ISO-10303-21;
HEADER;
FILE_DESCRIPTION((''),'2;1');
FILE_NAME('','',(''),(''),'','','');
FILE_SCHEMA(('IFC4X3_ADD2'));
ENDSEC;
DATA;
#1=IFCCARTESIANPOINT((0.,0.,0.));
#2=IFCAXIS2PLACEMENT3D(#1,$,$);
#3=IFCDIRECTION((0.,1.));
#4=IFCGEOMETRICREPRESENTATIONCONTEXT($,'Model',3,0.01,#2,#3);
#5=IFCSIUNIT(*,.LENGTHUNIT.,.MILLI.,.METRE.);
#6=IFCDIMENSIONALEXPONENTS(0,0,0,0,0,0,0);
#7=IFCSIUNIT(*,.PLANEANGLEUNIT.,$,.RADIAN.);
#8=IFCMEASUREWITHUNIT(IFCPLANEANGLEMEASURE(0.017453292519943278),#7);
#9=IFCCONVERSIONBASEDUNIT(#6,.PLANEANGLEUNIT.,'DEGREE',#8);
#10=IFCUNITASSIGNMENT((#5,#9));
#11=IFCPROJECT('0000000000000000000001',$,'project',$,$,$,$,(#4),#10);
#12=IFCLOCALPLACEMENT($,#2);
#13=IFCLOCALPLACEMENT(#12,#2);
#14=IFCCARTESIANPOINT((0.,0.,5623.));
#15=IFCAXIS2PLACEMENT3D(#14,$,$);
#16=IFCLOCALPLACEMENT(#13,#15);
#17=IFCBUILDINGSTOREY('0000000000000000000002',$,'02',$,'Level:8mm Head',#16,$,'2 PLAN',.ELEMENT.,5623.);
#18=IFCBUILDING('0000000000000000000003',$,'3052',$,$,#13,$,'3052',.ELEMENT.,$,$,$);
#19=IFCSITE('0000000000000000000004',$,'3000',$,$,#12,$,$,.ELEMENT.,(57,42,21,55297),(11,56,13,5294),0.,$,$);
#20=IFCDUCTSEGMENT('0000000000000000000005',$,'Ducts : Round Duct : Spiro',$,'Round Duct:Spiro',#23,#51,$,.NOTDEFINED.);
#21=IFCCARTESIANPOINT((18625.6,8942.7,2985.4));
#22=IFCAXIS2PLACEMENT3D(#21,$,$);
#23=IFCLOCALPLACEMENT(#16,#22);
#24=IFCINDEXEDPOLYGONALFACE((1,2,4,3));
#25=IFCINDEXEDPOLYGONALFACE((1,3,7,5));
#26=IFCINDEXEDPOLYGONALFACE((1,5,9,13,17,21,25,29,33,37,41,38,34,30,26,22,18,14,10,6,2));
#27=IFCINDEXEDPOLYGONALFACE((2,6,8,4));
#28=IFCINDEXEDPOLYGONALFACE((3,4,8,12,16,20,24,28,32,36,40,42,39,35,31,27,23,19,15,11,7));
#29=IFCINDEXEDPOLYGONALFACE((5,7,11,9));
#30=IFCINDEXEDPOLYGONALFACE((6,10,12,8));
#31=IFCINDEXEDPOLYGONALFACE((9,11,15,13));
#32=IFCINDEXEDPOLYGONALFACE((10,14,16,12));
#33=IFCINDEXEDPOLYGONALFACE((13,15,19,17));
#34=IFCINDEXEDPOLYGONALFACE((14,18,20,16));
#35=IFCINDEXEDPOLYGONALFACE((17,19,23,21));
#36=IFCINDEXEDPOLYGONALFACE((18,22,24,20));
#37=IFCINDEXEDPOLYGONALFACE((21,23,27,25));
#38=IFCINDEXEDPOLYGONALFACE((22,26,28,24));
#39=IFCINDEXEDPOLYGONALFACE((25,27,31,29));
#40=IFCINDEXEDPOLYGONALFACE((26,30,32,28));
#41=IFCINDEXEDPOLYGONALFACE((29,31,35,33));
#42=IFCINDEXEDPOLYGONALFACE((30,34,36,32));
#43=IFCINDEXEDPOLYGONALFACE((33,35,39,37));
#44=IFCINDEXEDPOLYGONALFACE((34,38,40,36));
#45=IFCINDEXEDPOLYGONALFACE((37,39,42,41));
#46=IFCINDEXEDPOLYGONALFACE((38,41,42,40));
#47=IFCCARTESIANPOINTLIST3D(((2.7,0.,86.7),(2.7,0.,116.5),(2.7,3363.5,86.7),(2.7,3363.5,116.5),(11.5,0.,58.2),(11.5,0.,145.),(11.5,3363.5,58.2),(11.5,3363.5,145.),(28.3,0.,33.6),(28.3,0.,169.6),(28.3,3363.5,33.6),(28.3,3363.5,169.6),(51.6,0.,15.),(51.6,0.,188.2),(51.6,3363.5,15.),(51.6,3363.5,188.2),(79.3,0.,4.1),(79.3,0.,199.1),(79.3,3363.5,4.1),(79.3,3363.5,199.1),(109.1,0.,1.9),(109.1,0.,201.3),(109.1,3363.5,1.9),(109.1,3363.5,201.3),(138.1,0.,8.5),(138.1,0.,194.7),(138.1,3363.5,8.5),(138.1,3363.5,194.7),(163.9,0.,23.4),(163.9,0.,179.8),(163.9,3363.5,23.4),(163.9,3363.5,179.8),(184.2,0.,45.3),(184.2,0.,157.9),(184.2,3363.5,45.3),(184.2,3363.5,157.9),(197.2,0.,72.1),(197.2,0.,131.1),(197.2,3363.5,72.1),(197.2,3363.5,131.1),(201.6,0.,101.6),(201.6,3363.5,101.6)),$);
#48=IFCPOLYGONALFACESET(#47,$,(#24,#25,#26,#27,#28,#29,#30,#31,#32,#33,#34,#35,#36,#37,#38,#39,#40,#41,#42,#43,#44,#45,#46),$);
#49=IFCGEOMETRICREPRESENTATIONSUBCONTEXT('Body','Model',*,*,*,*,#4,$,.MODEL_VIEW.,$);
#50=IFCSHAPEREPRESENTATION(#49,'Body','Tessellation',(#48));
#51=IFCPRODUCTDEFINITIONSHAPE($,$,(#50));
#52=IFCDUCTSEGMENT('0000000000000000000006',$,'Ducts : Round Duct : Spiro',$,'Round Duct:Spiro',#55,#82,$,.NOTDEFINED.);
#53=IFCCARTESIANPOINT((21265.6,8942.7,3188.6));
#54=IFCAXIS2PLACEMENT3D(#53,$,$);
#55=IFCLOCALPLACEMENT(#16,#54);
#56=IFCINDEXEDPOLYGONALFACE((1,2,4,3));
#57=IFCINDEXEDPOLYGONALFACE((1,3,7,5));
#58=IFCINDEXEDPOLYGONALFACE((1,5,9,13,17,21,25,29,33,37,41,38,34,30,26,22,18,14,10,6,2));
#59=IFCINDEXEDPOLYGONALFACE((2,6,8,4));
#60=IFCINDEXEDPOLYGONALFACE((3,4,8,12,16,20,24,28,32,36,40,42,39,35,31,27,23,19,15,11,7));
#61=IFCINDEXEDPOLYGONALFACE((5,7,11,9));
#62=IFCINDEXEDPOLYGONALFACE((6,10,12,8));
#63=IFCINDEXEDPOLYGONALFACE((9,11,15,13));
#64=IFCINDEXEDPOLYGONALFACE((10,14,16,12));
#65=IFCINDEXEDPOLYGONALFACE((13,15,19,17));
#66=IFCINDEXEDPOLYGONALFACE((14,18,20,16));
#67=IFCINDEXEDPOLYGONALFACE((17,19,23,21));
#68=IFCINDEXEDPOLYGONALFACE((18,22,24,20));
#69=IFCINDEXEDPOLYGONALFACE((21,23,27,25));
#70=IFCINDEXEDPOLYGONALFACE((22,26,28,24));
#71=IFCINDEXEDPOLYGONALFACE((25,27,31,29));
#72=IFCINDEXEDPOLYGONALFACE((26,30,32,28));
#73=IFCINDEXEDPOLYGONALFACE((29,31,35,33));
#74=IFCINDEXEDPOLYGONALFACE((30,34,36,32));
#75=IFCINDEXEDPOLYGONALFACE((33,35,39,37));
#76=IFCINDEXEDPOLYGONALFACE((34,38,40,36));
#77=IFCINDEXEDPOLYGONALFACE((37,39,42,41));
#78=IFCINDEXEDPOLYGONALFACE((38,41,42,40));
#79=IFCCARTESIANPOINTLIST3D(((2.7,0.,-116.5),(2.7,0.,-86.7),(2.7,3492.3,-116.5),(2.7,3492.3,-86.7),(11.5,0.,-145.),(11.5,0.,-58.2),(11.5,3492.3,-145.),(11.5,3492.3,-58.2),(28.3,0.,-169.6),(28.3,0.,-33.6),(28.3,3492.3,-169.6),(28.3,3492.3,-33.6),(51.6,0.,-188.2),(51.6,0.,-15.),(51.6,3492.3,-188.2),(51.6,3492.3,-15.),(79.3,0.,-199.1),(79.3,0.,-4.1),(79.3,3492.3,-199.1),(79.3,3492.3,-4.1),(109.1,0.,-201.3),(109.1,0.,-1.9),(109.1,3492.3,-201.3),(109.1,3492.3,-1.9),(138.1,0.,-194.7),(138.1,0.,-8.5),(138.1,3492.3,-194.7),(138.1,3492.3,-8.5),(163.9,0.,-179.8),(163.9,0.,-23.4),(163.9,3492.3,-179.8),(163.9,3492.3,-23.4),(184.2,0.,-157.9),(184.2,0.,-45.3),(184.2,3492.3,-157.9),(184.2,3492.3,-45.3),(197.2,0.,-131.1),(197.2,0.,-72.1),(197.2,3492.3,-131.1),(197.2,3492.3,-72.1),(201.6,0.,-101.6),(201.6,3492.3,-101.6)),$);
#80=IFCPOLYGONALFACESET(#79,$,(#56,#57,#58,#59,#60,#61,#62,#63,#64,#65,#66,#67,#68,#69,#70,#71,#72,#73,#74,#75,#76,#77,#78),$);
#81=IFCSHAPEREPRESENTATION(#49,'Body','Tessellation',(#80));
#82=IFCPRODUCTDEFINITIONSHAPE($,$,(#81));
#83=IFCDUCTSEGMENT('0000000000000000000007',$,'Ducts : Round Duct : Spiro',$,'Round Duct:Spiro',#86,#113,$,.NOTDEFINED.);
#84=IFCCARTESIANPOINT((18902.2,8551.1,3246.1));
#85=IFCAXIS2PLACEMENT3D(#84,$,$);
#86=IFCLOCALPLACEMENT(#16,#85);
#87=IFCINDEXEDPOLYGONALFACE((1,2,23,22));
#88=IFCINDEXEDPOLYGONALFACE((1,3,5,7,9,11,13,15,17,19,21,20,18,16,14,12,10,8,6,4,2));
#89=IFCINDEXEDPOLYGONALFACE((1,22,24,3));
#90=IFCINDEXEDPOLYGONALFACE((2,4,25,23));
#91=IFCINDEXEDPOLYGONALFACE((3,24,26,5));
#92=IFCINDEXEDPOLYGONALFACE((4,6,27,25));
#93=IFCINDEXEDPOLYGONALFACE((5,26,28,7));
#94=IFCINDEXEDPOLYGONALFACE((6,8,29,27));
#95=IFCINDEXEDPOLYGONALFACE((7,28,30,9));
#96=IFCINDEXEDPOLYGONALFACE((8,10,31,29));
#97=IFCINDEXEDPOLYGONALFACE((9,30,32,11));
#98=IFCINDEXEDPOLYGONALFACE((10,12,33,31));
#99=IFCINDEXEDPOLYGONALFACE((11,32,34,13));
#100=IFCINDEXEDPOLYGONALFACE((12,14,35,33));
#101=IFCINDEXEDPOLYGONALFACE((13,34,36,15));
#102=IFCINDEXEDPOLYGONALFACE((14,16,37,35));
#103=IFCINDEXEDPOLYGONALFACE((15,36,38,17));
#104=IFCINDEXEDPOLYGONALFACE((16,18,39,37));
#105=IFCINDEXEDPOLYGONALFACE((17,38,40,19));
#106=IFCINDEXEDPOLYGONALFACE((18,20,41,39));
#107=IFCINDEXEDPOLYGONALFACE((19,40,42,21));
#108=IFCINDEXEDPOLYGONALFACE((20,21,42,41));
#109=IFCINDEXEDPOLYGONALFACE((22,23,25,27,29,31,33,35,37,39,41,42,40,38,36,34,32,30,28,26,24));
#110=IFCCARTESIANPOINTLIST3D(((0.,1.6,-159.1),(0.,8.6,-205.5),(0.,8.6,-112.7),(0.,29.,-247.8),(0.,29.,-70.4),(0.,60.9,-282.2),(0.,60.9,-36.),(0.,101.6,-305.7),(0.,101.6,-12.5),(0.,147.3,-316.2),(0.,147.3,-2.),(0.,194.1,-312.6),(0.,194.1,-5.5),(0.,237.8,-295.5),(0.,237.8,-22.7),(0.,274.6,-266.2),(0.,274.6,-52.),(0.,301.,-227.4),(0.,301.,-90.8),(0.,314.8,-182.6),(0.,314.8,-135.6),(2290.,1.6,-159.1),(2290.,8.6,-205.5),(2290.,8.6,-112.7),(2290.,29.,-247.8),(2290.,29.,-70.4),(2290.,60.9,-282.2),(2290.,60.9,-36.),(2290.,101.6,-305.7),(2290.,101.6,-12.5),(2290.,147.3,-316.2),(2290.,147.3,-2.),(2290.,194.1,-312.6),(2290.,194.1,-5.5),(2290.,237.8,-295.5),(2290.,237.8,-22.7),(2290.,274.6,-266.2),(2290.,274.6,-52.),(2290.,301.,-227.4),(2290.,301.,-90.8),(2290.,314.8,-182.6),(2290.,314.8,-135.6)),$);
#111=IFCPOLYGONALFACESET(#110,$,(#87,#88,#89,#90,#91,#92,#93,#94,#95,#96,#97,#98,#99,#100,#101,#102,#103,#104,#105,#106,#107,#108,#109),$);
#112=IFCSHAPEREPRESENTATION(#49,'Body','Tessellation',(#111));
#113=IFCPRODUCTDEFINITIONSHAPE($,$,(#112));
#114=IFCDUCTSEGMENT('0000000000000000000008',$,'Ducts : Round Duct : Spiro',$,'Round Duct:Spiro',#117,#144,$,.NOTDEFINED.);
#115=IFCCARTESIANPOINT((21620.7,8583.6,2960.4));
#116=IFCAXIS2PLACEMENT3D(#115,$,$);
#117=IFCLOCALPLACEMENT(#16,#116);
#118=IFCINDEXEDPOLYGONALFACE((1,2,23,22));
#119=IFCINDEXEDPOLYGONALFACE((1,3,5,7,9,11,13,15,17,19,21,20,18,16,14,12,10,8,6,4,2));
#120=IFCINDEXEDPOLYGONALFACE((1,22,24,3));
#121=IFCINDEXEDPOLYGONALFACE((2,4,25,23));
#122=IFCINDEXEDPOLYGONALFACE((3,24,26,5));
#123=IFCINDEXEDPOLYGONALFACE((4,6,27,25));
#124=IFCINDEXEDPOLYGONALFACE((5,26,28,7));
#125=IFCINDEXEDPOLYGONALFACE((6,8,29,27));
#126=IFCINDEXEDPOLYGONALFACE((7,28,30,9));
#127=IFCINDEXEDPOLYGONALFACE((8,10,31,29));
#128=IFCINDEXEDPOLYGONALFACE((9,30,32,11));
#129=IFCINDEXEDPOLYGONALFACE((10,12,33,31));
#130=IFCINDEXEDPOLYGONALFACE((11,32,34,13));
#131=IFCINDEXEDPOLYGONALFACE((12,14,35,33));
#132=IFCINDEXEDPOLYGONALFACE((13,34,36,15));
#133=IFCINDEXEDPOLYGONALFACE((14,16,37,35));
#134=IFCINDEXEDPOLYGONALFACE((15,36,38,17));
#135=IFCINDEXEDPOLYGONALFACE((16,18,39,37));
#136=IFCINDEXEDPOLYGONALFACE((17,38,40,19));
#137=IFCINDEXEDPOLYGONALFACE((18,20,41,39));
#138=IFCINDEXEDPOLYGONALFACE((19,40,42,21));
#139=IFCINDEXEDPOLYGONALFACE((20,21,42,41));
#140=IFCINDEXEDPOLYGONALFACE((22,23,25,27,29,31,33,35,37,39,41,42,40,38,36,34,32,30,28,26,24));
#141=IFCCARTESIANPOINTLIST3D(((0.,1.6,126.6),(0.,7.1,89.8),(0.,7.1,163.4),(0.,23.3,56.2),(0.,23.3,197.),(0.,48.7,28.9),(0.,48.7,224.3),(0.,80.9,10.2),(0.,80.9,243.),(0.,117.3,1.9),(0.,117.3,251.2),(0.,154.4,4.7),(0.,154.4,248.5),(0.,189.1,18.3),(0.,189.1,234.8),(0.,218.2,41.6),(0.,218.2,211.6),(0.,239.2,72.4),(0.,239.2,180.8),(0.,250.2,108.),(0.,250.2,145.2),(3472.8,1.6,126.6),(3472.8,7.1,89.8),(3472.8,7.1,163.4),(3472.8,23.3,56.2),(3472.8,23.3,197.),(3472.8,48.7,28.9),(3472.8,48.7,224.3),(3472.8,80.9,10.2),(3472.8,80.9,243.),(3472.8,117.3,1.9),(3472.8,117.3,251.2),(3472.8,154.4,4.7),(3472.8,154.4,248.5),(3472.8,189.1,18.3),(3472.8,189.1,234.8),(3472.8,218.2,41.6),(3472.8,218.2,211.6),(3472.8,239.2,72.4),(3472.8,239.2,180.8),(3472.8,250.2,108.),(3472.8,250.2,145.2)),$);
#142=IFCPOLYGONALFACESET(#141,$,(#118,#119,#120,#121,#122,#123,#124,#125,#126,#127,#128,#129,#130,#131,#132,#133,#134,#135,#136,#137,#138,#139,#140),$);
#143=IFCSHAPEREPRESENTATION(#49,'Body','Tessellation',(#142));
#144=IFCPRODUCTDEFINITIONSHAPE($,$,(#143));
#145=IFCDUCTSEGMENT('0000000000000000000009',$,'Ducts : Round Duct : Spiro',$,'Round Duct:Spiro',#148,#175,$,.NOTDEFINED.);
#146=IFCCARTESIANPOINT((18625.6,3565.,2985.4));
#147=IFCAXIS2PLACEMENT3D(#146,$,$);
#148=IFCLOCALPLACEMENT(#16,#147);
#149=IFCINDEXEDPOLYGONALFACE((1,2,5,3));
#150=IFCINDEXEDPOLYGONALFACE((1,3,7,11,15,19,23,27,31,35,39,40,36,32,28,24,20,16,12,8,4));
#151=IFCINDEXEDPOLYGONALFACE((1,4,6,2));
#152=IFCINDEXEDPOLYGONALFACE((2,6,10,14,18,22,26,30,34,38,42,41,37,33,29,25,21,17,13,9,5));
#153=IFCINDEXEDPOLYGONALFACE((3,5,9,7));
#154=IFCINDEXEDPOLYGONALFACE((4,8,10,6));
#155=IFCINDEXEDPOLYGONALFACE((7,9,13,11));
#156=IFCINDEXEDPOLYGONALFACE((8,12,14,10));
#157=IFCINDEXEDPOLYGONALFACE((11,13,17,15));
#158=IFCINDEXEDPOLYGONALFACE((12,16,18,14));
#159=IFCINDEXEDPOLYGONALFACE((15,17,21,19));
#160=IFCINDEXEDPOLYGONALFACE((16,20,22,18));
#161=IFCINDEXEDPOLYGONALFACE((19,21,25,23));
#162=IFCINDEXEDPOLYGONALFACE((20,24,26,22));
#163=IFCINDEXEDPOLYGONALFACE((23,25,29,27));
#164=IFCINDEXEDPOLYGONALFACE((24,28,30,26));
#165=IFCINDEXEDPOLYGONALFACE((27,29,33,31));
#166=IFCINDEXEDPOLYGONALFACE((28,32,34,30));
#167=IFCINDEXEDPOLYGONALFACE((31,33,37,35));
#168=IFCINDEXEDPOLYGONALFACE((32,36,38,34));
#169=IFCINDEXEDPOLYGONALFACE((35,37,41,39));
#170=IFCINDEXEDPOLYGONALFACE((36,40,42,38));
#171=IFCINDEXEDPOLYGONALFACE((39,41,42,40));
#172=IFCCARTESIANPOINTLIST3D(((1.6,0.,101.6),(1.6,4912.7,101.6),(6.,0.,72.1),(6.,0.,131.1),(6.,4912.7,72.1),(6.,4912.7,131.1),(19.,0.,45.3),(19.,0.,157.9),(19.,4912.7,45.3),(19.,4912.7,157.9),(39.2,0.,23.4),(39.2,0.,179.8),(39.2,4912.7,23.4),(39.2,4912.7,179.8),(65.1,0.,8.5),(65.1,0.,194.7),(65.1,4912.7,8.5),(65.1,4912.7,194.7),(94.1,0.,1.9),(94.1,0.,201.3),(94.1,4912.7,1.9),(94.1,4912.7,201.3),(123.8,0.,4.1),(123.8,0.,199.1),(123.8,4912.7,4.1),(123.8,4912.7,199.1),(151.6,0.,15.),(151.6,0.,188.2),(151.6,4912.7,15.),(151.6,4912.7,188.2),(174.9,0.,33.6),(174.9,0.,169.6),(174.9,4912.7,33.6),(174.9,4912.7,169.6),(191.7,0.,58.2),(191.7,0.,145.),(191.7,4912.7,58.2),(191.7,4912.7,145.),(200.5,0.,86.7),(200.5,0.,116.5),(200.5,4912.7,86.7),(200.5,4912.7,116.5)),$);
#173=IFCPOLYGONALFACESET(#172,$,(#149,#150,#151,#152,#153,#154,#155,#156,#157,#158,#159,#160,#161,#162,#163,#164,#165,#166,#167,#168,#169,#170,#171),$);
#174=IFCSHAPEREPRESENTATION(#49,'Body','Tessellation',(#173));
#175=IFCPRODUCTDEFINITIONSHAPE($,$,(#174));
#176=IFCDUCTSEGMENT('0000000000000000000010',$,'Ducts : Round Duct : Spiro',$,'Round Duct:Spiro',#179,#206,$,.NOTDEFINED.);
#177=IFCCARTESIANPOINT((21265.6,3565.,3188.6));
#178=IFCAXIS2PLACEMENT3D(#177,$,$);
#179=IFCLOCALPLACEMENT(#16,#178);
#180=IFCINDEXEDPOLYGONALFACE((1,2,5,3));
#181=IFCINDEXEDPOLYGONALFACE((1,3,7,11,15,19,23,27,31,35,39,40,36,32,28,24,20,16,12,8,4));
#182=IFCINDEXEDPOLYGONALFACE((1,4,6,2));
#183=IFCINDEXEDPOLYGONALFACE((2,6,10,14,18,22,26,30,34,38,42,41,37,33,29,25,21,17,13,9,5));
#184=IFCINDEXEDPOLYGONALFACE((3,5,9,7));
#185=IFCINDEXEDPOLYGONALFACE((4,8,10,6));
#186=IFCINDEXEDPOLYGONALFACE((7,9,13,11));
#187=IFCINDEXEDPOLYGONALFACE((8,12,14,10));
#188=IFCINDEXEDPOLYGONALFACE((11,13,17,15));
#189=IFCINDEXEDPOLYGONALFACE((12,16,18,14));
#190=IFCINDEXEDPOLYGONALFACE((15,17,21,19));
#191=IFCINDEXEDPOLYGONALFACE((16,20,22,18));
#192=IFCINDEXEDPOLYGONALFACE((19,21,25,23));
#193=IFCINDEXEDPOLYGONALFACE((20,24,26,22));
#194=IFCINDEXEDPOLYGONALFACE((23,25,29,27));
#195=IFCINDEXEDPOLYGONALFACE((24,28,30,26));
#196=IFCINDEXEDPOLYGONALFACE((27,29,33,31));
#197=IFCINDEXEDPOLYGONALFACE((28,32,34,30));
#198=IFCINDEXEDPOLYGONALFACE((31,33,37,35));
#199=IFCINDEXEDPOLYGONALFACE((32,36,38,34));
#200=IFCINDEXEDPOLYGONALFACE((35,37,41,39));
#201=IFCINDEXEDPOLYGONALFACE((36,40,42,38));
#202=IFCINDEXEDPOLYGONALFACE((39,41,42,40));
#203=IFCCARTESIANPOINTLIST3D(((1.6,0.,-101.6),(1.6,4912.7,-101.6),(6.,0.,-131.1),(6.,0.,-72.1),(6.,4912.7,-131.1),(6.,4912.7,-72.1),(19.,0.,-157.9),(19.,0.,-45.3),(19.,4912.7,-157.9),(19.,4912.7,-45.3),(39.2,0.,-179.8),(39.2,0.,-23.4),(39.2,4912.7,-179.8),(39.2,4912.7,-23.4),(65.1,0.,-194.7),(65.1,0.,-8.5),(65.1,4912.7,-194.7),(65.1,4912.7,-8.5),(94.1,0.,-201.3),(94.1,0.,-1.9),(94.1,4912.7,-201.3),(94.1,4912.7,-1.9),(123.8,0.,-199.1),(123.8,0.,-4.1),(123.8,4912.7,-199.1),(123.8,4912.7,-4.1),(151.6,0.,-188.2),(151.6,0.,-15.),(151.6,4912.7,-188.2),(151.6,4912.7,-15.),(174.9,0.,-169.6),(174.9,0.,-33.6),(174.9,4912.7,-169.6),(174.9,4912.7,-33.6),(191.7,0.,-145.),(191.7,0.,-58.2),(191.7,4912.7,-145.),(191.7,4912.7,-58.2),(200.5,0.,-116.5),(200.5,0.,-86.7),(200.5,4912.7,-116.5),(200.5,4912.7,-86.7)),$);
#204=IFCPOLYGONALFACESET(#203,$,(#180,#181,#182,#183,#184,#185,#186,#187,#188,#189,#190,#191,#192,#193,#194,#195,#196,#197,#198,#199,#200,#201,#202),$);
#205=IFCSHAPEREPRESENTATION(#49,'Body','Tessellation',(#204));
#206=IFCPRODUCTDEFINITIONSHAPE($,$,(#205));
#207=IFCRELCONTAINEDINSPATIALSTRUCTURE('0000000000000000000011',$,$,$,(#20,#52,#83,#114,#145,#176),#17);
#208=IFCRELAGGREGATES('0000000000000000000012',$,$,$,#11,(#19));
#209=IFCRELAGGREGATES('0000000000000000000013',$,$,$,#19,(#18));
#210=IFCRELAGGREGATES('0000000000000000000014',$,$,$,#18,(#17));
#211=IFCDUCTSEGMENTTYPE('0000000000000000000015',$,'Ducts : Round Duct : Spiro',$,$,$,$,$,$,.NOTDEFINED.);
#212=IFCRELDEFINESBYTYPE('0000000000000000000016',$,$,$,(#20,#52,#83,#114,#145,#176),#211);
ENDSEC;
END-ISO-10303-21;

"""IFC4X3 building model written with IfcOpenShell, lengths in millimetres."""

from ifc_helpers import new_model, entity, si_unit, converted_unit, direction, frame, frame_2d, origin, origin_2d_with_axis, place, context, subcontext, project, spatial, circle, extrude, type_object, element, save


model = new_model("IFC4X3")

# Units and contexts
model_context = context("Model", 3, precision=0.01, world=origin(), true_north=direction((0.0, 1.0)))
body_context = subcontext(model_context, "Body", "Model", "MODEL_VIEW")
ifc_project = project(units=[si_unit("LENGTHUNIT", "METRE", prefix="MILLI"), converted_unit("PLANEANGLEUNIT", "DEGREE", entity("IfcPlaneAngleMeasure", 0.017453292519943278), si_unit("PLANEANGLEUNIT", "RADIAN"), dimensions=[0, 0, 0, 0, 0, 0, 0])], contexts=[model_context])

# Site, building, storey
site_placement = place(None, origin())
site = spatial("IfcSite", under=ifc_project, at=site_placement, Name="3000", CompositionType="ELEMENT", RefLatitude=(57, 42, 21, 55297), RefLongitude=(11, 56, 13, 5294), RefElevation=0.0)
building_placement = place(site_placement, origin())
building = spatial("IfcBuilding", under=site, at=building_placement, Name="3052", LongName="3052", CompositionType="ELEMENT")
storey_placement = place(building_placement, frame((0.0, 0.0, 5623.0)))
storey = spatial("IfcBuildingStorey", under=building, at=storey_placement, Name="02", ObjectType="Level:8mm Head", LongName="2 PLAN", CompositionType="ELEMENT", Elevation=5623.0)

# Duct segments
duct_segment_type = type_object("IfcDuctSegmentType", Name="Ducts : Round Duct : Spiro", PredefinedType="NOTDEFINED")
duct_segment_1_placement = place(storey_placement, frame((18625.6, 8942.7, 2985.4)))
element("IfcDuctSegment", 1, at=duct_segment_1_placement, inside=storey, type_object=duct_segment_type, Name="Ducts : Round Duct : Spiro", ObjectType="Round Duct:Spiro", PredefinedType="NOTDEFINED", context=body_context, shape_type="SweptSolid", body=[
    extrude(circle(Radius=100.0, at=frame_2d((0.0, 0.0), x_axis=(1.0, 0.0))), frame((101.6, 0.0, 101.6), z_axis=(0.0, 1.0, 0.0), x_axis=(1.0, 0.0, 0.0)), (0.0, 0.0, 1.0), 3363.5),
])
duct_segment_2_placement = place(storey_placement, frame((21265.6, 8942.7, 3188.6)))
element("IfcDuctSegment", 2, at=duct_segment_2_placement, inside=storey, type_object=duct_segment_type, Name="Ducts : Round Duct : Spiro", ObjectType="Round Duct:Spiro", PredefinedType="NOTDEFINED", context=body_context, shape_type="SweptSolid", body=[
    extrude(circle(Radius=100.0, at=frame_2d((0.0, 0.0), x_axis=(1.0, 0.0))), frame((101.6, 0.0, -101.6), z_axis=(0.0, 1.0, 0.0), x_axis=(1.0, 0.0, 0.0)), (0.0, 0.0, 1.0), 3492.3),
])
duct_segment_3_placement = place(storey_placement, frame((18902.2, 8551.1, 3246.1)))
element("IfcDuctSegment", 3, at=duct_segment_3_placement, inside=storey, type_object=duct_segment_type, Name="Ducts : Round Duct : Spiro", ObjectType="Round Duct:Spiro", PredefinedType="NOTDEFINED", context=body_context, shape_type="SweptSolid", body=[
    extrude(circle(Radius=157.5, at=frame_2d((0.0, 0.0), x_axis=(1.0, 0.0))), frame((0.0, 159.1, -159.1), z_axis=(1.0, 0.0, 0.0), x_axis=(0.0, -1.0, 0.0)), (0.0, 0.0, 1.0), 2290.0),
])
duct_segment_4_placement = place(storey_placement, frame((21620.7, 8583.6, 2960.4)))
element("IfcDuctSegment", 4, at=duct_segment_4_placement, inside=storey, type_object=duct_segment_type, Name="Ducts : Round Duct : Spiro", ObjectType="Round Duct:Spiro", PredefinedType="NOTDEFINED", context=body_context, shape_type="SweptSolid", body=[
    extrude(circle(Radius=125.0, at=origin_2d_with_axis()), frame((0.0, 126.6, 126.6), z_axis=(1.0, 0.0, 0.0), x_axis=(0.0, -1.0, 0.0)), (0.0, 0.0, 1.0), 3472.8),
])
duct_segment_5_placement = place(storey_placement, frame((18625.6, 3565.0, 2985.4)))
element("IfcDuctSegment", 5, at=duct_segment_5_placement, inside=storey, type_object=duct_segment_type, Name="Ducts : Round Duct : Spiro", ObjectType="Round Duct:Spiro", PredefinedType="NOTDEFINED", context=body_context, shape_type="SweptSolid", body=[
    extrude(circle(Radius=100.0, at=frame_2d((0.0, 0.0), x_axis=(1.0, 0.0))), frame((101.6, 0.0, 101.6), z_axis=(0.0, 1.0, 0.0), x_axis=(-1.0, 0.0, 0.0)), (0.0, 0.0, 1.0), 4912.7),
])
duct_segment_6_placement = place(storey_placement, frame((21265.6, 3565.0, 3188.6)))
element("IfcDuctSegment", 6, at=duct_segment_6_placement, inside=storey, type_object=duct_segment_type, Name="Ducts : Round Duct : Spiro", ObjectType="Round Duct:Spiro", PredefinedType="NOTDEFINED", context=body_context, shape_type="SweptSolid", body=[
    extrude(circle(Radius=100.0, at=frame_2d((0.0, 0.0), x_axis=(1.0, 0.0))), frame((101.6, 0.0, -101.6), z_axis=(0.0, 1.0, 0.0), x_axis=(-1.0, 0.0, 0.0)), (0.0, 0.0, 1.0), 4912.7),
])

save(model, "model.ifc")
